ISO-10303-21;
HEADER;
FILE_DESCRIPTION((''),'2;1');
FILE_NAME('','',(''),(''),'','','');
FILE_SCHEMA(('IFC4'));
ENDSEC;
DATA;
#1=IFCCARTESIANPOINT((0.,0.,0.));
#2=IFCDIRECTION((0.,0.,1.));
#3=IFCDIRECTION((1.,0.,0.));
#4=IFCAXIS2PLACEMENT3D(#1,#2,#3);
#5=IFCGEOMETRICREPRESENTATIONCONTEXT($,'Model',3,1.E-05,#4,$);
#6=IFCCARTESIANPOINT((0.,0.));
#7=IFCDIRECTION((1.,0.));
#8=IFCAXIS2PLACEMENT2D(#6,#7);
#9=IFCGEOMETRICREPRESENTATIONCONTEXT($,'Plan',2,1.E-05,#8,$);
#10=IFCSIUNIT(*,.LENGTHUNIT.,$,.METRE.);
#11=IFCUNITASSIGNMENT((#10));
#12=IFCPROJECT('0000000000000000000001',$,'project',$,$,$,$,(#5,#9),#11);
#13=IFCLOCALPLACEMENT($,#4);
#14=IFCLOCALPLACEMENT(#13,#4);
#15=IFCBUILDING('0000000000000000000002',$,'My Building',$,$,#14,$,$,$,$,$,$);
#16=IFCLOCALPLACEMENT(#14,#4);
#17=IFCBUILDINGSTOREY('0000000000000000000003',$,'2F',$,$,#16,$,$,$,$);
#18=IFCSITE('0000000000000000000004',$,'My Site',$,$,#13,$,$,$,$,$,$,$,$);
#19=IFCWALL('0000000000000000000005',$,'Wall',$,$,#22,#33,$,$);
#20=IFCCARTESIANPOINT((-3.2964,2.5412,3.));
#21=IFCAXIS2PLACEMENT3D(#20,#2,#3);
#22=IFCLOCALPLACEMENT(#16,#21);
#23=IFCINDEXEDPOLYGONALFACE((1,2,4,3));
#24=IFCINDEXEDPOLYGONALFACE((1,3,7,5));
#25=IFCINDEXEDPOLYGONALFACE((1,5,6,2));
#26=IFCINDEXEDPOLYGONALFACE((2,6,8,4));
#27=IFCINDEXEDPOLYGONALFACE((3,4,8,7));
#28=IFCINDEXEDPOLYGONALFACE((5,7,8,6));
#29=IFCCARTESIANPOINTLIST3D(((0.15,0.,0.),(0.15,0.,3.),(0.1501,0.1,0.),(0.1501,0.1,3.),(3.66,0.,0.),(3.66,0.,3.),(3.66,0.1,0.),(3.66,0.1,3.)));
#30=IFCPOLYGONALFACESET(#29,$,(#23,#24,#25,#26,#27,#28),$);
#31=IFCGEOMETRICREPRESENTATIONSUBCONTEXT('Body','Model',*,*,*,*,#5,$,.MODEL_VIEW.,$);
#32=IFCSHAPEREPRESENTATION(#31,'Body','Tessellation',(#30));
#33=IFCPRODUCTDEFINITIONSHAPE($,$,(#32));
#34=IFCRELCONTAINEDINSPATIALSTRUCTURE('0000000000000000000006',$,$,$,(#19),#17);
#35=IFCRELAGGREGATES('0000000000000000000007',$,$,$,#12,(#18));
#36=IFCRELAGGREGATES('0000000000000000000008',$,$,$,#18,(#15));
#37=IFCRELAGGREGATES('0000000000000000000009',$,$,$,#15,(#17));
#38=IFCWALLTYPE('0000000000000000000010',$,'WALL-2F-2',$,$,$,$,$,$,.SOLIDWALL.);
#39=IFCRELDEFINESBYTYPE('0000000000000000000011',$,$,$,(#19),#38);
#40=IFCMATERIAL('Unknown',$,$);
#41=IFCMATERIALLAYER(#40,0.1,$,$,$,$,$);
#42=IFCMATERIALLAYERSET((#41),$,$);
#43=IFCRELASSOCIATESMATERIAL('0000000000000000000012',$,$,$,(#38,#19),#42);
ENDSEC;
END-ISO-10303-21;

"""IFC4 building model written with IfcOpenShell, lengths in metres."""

from ifc_helpers import new_model, si_unit, frame, origin_with_axes, origin_2d_with_axis, place, context, subcontext, project, spatial, line, indexed_curve, outline, extrude, material, layer, layer_set, layer_usage, type_object, element, save


model = new_model("IFC4")

# Units and contexts
model_context = context("Model", 3, precision=1e-05, world=origin_with_axes())
plan_context = context("Plan", 2, precision=1e-05, world=origin_2d_with_axis())
body_context_1 = subcontext(model_context, "Body", "Model", "MODEL_VIEW")
ifc_project = project(units=[si_unit("LENGTHUNIT", "METRE")], contexts=[model_context, plan_context])

# Site, building, storey
site_placement = place(None, origin_with_axes())
site = spatial("IfcSite", under=ifc_project, at=site_placement, Name="My Site")
building_placement = place(site_placement, origin_with_axes())
building = spatial("IfcBuilding", under=site, at=building_placement, Name="My Building")
storey_placement = place(building_placement, origin_with_axes())
storey = spatial("IfcBuildingStorey", under=building, at=storey_placement, Name="2F")

# Shared definitions
ifc_material = material(Name="Unknown")

# Shared definitions
ifc_layer_1 = layer(ifc_material, 0.1)
ifc_layer_set_1 = layer_set([ifc_layer_1])
wall_type_1 = type_object("IfcWallType", Name="WALL-2F-2", PredefinedType="SOLIDWALL", material=ifc_layer_set_1)

# Wall
ifc_layer_usage_1 = layer_usage(ifc_layer_set_1, "AXIS2", "POSITIVE", 0.0)
wall_1_placement = place(storey_placement, frame((-3.2964, 2.5412, 3.0), z_axis=(0.0, 0.0, 1.0), x_axis=(1.0, 0.0, 0.0)))
element("IfcWall", 1, at=wall_1_placement, inside=storey, type_object=wall_type_1, material=ifc_layer_usage_1, Name="Wall", context=body_context_1, shape_type="SweptSolid", body=[
    extrude(outline(indexed_curve([(0.15, 0.0), (0.1501, 0.1), (3.66, 0.1), (3.66, 0.0)], segments=[line(1, 2, 3, 4, 1)])), origin_with_axes(), (0.0, 0.0, 1.0), 3.0),
])

save(model, "model.ifc")
